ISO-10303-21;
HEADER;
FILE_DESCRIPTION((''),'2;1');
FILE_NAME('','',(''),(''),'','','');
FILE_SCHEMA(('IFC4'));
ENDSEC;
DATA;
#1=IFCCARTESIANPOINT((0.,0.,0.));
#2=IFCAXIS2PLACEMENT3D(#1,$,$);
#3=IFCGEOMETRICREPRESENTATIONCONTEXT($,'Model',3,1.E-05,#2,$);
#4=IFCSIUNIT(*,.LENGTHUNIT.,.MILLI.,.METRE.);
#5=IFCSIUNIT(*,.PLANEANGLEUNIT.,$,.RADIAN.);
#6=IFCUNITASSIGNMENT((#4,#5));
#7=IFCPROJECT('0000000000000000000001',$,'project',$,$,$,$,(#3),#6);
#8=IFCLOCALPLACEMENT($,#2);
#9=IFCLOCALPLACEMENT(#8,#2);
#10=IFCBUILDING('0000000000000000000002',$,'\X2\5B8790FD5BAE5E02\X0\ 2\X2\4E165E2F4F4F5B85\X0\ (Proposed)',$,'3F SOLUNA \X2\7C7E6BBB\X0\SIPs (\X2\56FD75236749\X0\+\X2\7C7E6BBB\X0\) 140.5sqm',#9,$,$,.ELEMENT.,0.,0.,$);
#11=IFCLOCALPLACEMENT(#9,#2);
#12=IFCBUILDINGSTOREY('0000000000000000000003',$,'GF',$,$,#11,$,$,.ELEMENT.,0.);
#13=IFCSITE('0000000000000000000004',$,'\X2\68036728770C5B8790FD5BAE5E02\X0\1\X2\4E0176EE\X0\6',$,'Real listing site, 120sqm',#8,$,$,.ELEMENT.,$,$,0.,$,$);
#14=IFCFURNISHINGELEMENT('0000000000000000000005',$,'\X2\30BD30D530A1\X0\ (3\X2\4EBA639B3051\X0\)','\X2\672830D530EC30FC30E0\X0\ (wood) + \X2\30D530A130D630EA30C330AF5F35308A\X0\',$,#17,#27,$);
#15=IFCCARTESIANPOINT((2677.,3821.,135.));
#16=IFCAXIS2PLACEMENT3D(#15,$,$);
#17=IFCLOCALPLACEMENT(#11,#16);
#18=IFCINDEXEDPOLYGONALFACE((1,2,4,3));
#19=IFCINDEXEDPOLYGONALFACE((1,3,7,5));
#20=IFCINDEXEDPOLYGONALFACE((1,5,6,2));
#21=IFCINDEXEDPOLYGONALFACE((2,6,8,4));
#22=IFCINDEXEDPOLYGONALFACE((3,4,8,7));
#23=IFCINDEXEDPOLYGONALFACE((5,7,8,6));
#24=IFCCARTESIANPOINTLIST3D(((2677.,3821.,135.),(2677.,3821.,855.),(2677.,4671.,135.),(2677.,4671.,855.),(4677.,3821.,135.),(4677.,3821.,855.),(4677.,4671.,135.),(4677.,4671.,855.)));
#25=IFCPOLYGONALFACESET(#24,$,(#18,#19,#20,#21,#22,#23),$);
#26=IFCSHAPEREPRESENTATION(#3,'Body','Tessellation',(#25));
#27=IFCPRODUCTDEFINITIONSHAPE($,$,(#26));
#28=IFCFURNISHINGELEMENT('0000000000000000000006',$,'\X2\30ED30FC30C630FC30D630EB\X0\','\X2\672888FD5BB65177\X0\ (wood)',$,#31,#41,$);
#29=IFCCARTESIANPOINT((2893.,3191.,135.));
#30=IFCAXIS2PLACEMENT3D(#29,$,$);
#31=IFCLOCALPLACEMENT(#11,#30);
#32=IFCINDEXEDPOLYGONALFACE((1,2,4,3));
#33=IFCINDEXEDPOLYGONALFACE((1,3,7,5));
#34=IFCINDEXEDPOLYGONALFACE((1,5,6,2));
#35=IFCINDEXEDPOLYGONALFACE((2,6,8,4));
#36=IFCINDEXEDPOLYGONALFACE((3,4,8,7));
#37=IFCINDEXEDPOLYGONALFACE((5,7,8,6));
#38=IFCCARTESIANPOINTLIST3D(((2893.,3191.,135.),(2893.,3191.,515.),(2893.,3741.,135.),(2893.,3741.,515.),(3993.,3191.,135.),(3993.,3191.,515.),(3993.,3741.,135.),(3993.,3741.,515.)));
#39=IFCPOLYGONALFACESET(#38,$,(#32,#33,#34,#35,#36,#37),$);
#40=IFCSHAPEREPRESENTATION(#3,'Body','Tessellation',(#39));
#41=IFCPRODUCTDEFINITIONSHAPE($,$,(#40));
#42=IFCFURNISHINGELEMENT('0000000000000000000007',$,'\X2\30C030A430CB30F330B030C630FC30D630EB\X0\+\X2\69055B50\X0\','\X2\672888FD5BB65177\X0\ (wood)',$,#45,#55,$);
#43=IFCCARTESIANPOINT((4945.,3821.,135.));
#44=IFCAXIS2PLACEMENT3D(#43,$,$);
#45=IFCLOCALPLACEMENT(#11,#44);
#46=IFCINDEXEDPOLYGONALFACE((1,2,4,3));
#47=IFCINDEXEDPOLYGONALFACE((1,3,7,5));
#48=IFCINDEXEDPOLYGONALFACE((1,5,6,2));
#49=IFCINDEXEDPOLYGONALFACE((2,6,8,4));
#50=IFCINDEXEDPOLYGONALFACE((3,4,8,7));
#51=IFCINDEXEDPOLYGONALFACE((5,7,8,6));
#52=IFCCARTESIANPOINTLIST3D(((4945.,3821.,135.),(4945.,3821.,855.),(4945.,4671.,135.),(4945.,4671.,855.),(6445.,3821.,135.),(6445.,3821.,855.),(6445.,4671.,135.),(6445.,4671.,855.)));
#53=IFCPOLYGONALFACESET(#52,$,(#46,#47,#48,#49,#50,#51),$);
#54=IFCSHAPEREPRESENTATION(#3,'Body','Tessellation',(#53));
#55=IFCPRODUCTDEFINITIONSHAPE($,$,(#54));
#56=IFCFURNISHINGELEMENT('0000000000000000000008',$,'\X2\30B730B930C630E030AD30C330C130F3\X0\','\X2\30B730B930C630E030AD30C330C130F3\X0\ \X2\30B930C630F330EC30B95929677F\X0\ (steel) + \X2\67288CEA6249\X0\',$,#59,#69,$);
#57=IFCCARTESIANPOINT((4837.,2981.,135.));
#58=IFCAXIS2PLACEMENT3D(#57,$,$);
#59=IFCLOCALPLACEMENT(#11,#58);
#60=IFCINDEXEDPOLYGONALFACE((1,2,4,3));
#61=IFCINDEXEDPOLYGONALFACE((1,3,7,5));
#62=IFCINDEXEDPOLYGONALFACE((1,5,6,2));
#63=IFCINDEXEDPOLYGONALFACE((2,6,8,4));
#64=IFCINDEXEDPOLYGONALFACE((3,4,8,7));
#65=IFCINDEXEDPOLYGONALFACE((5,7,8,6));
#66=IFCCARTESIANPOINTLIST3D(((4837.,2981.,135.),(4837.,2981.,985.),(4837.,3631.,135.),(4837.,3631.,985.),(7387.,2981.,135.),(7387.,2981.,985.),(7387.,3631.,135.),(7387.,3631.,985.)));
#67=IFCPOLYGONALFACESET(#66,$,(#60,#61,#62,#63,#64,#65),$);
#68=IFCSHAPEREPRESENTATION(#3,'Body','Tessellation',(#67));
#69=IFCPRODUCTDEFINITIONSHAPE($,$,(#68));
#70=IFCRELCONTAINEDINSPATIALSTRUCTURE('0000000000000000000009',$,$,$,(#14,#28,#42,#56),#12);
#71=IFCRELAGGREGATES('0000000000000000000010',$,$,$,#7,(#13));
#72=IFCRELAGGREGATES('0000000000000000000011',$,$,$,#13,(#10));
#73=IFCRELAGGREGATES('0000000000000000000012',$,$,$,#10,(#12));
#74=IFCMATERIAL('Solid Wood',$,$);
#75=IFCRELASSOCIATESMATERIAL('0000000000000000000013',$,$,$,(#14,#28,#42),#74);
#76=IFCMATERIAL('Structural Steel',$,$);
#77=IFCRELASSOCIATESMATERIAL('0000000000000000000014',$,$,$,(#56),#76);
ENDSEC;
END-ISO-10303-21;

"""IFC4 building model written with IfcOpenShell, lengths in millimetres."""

from ifc_helpers import new_model, si_unit, frame, frame_2d, origin, place, context, project, spatial, rectangle, extrude, material, element, save


model = new_model("IFC4")

# Units and contexts
model_context = context("Model", 3, precision=1e-05, world=origin())
ifc_project = project(units=[si_unit("LENGTHUNIT", "METRE", prefix="MILLI"), si_unit("PLANEANGLEUNIT", "RADIAN")], contexts=[model_context])

# Site, building, storey
site_placement = place(None, origin())
site = spatial("IfcSite", under=ifc_project, at=site_placement, Name="栃木県宇都宮市1丁目6", ObjectType="Real listing site, 120sqm", CompositionType="ELEMENT", RefElevation=0.0)
building_placement = place(site_placement, origin())
building = spatial("IfcBuilding", under=site, at=building_placement, Name="宇都宮市 2世帯住宅 (Proposed)", ObjectType="3F SOLUNA 籾殻SIPs (国産杉+籾殻) 140.5sqm", CompositionType="ELEMENT", ElevationOfRefHeight=0.0, ElevationOfTerrain=0.0)
storey_placement = place(building_placement, origin())
storey = spatial("IfcBuildingStorey", under=building, at=storey_placement, Name="GF", CompositionType="ELEMENT", Elevation=0.0)

# Shared definitions
ifc_material_1 = material(Name="Solid Wood")

# Furnishing elements
furnishing_1_placement = place(storey_placement, frame((2677.0, 3821.0, 135.0)))
element("IfcFurnishingElement", 1, at=furnishing_1_placement, inside=storey, material=ifc_material_1, Name="ソファ (3人掛け)", Description="木フレーム (wood) + ファブリック張り", context=model_context, shape_type="SweptSolid", body=[
    extrude(rectangle(XDim=2000.0, YDim=850.0, at=frame_2d((1000.0, 425.0))), frame((2677.0, 3821.0, 135.0)), (0.0, 0.0, 1.0), 720.0),
])
furnishing_2_placement = place(storey_placement, frame((2893.0, 3191.0, 135.0)))
element("IfcFurnishingElement", 2, at=furnishing_2_placement, inside=storey, material=ifc_material_1, Name="ローテーブル", Description="木製家具 (wood)", context=model_context, shape_type="SweptSolid", body=[
    extrude(rectangle(XDim=1100.0, YDim=550.0, at=frame_2d((550.0, 275.0))), frame((2893.0, 3191.0, 135.0)), (0.0, 0.0, 1.0), 380.0),
])
furnishing_3_placement = place(storey_placement, frame((4945.0, 3821.0, 135.0)))
element("IfcFurnishingElement", 3, at=furnishing_3_placement, inside=storey, material=ifc_material_1, Name="ダイニングテーブル+椅子", Description="木製家具 (wood)", context=model_context, shape_type="SweptSolid", body=[
    extrude(rectangle(XDim=1500.0, YDim=850.0, at=frame_2d((750.0, 425.0))), frame((4945.0, 3821.0, 135.0)), (0.0, 0.0, 1.0), 720.0),
])
ifc_material_2 = material(Name="Structural Steel")
furnishing_4_placement = place(storey_placement, frame((4837.0, 2981.0, 135.0)))
element("IfcFurnishingElement", 4, at=furnishing_4_placement, inside=storey, material=ifc_material_2, Name="システムキッチン", Description="システムキッチン ステンレス天板 (steel) + 木質扉", context=model_context, shape_type="SweptSolid", body=[
    extrude(rectangle(XDim=2550.0, YDim=650.0, at=frame_2d((1275.0, 325.0))), frame((4837.0, 2981.0, 135.0)), (0.0, 0.0, 1.0), 850.0),
])

save(model, "model.ifc")
